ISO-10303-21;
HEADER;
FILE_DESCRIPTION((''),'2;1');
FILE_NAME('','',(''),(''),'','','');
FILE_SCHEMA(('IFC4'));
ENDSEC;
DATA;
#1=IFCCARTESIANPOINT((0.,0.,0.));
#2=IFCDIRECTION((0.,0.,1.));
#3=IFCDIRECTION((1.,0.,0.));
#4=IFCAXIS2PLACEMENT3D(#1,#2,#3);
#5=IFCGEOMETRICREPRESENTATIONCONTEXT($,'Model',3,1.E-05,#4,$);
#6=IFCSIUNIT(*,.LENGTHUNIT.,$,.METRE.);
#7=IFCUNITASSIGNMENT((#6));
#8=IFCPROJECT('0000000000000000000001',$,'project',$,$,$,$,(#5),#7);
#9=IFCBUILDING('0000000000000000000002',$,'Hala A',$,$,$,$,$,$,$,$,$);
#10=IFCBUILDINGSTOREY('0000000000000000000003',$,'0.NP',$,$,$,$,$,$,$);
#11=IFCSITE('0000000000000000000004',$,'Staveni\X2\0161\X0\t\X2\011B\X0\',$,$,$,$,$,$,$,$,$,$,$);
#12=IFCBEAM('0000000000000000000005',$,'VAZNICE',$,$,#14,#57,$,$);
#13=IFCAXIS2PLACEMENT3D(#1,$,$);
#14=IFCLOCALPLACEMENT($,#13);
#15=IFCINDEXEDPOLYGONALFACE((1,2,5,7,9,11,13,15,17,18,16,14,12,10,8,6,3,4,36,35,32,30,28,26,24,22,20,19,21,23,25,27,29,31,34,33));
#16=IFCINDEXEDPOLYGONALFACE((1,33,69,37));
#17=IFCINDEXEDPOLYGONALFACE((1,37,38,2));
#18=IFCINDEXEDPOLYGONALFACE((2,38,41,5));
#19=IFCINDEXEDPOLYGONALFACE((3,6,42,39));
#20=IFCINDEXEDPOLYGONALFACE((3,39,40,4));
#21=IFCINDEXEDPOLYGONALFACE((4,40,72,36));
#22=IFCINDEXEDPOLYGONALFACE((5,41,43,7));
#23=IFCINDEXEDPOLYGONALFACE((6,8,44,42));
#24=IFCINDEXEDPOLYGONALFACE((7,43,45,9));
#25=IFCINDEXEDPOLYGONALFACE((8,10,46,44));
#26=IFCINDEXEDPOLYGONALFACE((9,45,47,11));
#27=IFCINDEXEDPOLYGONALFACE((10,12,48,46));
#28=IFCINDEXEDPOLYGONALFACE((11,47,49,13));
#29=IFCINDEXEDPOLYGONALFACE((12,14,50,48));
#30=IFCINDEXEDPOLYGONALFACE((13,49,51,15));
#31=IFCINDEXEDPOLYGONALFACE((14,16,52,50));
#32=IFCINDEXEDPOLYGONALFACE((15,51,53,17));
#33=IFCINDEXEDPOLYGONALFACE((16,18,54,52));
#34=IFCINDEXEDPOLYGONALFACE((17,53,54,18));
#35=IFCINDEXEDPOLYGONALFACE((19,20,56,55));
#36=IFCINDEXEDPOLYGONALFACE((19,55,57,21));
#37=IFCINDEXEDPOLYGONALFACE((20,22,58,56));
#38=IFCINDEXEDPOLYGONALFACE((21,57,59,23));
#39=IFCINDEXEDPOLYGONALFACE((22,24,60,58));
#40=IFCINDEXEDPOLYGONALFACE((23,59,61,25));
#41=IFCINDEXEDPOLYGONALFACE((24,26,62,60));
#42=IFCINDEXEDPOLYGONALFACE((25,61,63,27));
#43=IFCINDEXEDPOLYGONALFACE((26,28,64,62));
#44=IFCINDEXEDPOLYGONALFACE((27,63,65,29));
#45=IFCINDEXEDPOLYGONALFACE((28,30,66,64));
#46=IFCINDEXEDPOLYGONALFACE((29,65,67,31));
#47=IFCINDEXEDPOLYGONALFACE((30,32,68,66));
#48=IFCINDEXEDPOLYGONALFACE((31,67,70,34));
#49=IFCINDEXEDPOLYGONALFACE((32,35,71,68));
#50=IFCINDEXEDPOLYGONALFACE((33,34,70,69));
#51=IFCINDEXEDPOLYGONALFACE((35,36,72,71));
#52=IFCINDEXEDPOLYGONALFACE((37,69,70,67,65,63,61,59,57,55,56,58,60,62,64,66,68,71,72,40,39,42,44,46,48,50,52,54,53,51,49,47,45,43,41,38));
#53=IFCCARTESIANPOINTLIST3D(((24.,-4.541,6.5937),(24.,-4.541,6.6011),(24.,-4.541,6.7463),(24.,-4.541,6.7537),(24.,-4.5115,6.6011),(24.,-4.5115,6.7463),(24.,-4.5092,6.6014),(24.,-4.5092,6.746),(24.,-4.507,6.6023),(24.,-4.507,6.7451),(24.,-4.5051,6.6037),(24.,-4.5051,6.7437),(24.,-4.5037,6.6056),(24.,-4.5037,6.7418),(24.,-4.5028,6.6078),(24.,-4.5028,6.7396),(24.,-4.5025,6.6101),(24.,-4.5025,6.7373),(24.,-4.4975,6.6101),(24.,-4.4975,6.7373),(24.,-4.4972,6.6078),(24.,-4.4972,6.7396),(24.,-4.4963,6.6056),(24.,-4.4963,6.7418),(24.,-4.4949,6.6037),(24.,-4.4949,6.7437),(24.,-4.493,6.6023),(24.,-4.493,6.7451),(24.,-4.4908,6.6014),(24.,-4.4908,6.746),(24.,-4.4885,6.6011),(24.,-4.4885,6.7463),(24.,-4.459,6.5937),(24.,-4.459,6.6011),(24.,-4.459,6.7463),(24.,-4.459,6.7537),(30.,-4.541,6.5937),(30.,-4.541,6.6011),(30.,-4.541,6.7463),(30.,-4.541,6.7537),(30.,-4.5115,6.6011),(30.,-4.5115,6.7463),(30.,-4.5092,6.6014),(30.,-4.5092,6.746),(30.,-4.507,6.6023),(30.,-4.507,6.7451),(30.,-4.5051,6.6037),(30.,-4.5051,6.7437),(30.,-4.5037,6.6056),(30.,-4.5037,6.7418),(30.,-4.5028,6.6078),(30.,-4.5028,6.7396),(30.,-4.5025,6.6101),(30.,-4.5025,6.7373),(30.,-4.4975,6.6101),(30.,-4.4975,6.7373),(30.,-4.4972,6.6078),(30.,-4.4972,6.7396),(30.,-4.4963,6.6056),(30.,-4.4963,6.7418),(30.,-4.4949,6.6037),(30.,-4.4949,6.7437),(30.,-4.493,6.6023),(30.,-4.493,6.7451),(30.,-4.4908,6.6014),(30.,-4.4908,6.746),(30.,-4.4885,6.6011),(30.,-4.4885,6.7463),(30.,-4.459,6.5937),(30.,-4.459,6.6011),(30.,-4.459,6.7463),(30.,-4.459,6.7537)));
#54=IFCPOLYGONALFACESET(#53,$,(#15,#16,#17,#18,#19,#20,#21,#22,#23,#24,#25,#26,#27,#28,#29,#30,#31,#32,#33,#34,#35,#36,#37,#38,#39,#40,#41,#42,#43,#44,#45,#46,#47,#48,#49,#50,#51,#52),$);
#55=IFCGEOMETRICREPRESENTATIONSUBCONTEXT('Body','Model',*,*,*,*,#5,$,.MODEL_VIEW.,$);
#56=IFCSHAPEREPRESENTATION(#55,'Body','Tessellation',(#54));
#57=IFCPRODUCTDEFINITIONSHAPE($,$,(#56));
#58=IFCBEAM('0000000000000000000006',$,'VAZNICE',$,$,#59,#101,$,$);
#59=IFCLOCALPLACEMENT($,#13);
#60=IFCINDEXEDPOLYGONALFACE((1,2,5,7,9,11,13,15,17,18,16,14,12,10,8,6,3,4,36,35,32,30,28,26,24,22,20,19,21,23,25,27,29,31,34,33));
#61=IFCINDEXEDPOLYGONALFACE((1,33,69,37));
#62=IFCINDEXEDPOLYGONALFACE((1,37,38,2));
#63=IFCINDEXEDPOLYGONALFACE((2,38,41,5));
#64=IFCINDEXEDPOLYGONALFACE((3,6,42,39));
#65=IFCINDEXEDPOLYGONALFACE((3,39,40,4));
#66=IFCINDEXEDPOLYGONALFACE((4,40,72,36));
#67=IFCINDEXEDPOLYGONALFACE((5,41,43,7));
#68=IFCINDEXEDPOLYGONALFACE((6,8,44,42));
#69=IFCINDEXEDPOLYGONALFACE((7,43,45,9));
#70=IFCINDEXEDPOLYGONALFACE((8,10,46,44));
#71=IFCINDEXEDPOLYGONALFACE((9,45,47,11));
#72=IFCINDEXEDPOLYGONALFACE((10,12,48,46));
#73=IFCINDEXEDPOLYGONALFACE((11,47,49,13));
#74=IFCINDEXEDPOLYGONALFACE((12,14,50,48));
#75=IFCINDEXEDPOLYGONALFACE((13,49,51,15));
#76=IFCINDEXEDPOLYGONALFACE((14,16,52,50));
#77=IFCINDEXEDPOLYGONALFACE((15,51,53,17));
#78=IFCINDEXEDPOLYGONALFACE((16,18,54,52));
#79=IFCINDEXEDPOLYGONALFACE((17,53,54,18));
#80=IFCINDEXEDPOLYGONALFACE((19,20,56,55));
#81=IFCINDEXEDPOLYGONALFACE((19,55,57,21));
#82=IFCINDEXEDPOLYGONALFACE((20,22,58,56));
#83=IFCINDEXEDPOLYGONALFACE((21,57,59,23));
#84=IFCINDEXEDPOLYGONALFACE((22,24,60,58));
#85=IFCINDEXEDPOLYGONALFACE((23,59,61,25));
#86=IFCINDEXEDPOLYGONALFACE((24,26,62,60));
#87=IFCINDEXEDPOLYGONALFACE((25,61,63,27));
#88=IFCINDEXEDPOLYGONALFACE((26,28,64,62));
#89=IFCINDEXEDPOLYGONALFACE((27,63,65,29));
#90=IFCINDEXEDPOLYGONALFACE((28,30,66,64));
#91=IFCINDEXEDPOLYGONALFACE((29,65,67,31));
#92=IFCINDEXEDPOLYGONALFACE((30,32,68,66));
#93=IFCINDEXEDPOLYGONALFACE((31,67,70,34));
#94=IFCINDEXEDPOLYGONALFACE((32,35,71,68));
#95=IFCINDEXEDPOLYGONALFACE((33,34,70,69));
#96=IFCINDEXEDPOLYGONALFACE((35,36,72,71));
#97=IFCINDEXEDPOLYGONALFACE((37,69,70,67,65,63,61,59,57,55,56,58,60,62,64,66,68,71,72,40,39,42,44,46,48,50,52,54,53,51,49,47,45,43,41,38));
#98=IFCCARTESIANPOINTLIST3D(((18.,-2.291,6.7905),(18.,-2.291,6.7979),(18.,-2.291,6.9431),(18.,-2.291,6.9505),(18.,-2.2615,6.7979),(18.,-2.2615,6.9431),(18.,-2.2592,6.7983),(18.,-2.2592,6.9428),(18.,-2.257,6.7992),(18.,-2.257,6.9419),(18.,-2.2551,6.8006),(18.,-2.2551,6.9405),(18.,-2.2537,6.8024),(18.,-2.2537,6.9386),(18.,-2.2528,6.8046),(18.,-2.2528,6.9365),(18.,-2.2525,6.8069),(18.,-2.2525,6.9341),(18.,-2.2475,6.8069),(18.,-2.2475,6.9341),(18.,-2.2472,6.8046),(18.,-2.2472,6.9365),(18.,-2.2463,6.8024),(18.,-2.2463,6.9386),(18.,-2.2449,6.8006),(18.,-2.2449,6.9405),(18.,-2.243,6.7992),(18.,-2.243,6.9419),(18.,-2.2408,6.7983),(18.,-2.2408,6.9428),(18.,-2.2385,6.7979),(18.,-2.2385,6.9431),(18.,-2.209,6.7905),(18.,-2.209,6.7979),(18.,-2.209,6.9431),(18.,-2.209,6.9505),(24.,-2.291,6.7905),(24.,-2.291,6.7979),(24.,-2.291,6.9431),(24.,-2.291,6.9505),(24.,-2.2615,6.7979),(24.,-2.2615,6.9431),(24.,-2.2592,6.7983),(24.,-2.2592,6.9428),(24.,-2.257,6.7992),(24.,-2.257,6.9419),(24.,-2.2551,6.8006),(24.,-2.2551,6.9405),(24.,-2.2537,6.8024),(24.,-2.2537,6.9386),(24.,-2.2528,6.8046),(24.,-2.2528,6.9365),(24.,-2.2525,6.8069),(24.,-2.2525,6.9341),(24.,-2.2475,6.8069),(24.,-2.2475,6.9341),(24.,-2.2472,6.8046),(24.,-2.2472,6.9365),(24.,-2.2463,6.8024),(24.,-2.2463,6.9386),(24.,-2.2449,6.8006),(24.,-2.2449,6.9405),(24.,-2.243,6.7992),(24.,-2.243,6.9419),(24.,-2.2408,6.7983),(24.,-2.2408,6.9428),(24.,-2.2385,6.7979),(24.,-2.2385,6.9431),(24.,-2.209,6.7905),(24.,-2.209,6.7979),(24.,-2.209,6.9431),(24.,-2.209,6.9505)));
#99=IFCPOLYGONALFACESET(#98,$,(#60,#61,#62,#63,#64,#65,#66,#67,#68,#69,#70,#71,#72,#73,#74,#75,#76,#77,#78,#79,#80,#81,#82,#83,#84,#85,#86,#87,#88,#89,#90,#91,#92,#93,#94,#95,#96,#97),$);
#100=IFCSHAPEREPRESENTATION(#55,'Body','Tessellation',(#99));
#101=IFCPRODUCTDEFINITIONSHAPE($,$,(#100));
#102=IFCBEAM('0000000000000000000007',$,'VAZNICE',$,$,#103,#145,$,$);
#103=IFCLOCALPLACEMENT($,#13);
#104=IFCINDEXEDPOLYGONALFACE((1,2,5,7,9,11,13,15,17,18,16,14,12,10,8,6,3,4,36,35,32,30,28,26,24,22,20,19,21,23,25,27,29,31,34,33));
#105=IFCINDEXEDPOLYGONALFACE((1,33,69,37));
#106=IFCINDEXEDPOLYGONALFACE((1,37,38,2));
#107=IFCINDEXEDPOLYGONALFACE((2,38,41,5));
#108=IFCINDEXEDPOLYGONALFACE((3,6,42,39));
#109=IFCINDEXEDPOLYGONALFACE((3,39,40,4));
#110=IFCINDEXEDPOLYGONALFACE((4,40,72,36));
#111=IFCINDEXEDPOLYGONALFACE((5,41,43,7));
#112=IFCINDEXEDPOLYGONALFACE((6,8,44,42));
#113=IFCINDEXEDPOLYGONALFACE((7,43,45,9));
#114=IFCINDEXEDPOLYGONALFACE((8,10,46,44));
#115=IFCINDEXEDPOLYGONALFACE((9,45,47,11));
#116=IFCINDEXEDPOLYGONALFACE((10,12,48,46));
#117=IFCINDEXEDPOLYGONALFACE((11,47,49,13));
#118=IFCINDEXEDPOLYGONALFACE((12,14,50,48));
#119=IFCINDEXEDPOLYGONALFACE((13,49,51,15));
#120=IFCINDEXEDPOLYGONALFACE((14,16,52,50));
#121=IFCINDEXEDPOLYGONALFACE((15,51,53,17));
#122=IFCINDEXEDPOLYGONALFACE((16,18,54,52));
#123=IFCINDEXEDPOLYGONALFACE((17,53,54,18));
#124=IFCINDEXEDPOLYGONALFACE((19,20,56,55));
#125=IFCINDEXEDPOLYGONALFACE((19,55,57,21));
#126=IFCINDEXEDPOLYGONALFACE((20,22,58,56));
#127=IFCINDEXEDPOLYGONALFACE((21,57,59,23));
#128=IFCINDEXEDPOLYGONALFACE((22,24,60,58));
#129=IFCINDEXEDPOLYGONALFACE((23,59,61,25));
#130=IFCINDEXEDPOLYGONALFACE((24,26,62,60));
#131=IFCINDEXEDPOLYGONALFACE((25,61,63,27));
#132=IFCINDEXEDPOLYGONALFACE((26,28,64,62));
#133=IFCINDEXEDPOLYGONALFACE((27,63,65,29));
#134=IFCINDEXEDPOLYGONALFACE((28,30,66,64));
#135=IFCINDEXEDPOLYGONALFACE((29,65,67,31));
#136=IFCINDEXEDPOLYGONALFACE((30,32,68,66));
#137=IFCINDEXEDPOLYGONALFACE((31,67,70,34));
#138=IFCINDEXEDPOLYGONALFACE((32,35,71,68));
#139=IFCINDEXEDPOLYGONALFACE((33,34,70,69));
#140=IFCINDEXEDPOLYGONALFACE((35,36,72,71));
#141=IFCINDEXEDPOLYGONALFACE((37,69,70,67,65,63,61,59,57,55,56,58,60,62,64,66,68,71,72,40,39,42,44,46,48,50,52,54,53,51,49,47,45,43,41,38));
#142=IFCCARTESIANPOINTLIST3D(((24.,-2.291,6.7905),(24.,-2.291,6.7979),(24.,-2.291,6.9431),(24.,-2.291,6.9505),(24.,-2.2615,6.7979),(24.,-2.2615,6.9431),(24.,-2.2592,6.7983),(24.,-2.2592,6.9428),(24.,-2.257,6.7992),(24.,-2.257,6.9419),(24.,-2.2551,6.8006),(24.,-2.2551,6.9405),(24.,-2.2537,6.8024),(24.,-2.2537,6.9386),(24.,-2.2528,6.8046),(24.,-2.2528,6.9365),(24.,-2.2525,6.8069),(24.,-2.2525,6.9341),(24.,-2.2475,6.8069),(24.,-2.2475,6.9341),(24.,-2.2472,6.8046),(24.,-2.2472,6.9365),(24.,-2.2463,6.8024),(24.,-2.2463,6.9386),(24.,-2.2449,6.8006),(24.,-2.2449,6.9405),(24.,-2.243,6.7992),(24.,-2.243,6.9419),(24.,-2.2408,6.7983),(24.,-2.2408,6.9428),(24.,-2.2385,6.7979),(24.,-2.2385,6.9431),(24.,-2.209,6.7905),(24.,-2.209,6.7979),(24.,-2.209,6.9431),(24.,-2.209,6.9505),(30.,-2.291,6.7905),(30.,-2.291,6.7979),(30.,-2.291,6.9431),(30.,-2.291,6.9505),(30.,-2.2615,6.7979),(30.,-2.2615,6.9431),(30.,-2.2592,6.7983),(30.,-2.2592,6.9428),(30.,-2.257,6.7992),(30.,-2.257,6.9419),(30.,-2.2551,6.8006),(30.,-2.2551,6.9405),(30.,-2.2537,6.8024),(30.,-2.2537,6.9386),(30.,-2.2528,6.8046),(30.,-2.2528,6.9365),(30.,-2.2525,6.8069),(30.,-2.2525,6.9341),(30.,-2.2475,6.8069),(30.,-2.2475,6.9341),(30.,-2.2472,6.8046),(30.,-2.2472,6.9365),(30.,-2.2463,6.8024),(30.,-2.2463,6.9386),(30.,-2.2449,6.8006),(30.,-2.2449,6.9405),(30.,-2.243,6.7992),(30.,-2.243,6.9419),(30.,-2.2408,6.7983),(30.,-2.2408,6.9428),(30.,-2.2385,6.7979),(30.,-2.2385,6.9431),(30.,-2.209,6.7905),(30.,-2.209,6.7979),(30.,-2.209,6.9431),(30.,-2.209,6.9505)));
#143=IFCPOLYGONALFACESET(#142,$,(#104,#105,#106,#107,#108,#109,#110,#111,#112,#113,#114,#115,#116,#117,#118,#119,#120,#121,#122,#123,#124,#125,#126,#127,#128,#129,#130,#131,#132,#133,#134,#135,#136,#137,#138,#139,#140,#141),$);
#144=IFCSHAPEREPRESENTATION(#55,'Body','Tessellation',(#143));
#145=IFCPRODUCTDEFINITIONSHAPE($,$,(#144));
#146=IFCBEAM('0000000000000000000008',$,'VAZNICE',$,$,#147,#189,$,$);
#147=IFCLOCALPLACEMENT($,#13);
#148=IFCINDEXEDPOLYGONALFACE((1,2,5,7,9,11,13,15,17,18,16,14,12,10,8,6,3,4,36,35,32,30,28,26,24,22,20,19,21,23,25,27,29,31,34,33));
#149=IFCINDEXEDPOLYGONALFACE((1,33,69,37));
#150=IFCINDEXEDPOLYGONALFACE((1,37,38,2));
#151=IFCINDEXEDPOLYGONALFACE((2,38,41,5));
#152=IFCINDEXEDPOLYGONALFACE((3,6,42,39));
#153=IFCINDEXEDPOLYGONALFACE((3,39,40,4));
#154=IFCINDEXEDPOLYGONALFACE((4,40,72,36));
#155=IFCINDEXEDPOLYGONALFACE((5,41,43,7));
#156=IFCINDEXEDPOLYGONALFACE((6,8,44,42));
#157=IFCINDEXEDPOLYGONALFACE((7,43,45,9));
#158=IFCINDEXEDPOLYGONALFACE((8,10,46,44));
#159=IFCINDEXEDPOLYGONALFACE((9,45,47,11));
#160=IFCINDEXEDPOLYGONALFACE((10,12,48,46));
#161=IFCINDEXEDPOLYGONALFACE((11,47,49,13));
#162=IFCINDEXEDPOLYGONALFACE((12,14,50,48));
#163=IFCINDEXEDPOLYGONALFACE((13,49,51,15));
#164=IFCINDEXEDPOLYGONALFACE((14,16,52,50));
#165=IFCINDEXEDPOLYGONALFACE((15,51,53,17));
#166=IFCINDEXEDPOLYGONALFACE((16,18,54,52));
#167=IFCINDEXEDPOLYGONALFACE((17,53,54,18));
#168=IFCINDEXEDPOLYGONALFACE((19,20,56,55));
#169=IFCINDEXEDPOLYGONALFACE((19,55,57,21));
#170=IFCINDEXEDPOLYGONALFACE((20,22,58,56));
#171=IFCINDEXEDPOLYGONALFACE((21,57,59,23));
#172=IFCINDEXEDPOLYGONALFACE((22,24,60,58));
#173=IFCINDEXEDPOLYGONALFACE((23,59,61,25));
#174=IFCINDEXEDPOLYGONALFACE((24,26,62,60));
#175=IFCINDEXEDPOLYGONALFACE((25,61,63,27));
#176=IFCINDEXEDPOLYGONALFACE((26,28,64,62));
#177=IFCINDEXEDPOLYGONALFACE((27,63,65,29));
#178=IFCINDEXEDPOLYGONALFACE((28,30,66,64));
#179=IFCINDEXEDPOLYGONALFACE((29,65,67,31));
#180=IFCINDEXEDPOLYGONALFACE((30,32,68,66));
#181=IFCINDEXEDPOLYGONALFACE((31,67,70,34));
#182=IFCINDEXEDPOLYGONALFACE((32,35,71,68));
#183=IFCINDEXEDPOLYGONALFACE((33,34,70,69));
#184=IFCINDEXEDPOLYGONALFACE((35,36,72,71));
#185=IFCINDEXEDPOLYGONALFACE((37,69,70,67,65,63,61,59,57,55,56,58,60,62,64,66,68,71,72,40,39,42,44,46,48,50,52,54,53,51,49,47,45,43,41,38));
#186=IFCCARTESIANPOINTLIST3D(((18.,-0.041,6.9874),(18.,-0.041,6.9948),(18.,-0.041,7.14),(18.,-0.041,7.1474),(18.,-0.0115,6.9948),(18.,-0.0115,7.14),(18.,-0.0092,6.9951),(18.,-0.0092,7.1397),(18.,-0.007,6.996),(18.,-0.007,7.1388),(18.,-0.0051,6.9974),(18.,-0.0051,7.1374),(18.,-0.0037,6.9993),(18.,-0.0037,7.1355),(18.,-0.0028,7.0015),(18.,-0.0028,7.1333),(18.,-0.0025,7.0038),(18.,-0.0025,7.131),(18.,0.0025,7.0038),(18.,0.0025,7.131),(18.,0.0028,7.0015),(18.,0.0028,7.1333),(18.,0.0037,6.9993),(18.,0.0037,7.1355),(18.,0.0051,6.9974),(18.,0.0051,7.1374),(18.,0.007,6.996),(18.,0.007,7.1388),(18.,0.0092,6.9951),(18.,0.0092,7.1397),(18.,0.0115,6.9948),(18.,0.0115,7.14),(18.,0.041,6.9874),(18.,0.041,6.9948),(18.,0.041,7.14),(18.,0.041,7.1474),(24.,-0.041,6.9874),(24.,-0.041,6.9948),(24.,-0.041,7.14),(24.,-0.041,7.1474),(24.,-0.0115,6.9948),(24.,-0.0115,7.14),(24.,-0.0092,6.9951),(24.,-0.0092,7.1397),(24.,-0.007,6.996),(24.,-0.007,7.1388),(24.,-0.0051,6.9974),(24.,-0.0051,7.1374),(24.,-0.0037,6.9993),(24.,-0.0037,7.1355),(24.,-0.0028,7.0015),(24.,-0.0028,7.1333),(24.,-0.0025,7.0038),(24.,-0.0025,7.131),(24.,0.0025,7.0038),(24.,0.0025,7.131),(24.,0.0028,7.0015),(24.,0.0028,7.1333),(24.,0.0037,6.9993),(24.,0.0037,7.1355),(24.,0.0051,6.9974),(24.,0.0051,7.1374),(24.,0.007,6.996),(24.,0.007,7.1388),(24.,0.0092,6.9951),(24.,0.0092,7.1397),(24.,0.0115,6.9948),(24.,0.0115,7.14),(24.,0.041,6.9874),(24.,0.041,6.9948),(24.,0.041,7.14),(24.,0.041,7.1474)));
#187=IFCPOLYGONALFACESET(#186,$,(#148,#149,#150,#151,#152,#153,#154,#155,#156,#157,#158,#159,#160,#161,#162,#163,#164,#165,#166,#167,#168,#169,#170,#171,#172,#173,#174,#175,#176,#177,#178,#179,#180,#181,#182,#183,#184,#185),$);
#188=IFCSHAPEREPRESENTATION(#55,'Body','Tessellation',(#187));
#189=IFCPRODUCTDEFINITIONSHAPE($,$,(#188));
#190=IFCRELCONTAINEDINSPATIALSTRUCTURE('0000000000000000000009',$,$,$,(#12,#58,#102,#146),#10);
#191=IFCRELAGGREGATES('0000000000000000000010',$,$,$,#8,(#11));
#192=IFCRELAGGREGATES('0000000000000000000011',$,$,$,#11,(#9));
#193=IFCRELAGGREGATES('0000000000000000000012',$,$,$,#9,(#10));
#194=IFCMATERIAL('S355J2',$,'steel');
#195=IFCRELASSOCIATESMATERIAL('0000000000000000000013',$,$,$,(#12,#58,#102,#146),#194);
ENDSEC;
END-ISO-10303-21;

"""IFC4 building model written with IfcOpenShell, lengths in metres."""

from ifc_helpers import new_model, si_unit, frame, origin_with_axes, place, context, subcontext, project, spatial, i_section, extrude, material, element, save


model = new_model("IFC4")

# Units and contexts
model_context = context("Model", 3, precision=1e-05, world=origin_with_axes())
body_context = subcontext(model_context, "Body", "Model", "MODEL_VIEW")
ifc_project = project(units=[si_unit("LENGTHUNIT", "METRE")], contexts=[model_context])

# Site, building, storey
site = spatial("IfcSite", under=ifc_project, Name="Staveniště")
building = spatial("IfcBuilding", under=site, Name="Hala A")
storey = spatial("IfcBuildingStorey", under=building, Name="0.NP")

# Shared definitions
ifc_material = material(Name="S355J2", Category="steel")

# Beams
for number, where, z_axis, x_axis, name in (
    (1, (24.0, -4.5, 6.6737), (1.0, 0.0, 0.0), (0.0, 1.0, 0.0), "VAZNICE"),
    (2, (18.0, -2.25, 6.8705), (1.0, 0.0, 0.0), (0.0, 1.0, 0.0), "VAZNICE"),
    (3, (24.0, -2.25, 6.8705), (1.0, 0.0, 0.0), (0.0, 1.0, 0.0), "VAZNICE"),
    (4, (18.0, 0.0, 7.0674), (1.0, 0.0, 0.0), (0.0, 1.0, 0.0), "VAZNICE"),
):
    element("IfcBeam", number, at=place(None, frame(where, z_axis=z_axis, x_axis=x_axis)), inside=storey, material=ifc_material, Name=name, context=body_context, shape_type="SweptSolid", body=[
        extrude(i_section(OverallWidth=0.082, OverallDepth=0.16, WebThickness=0.005, FlangeThickness=0.0074, FilletRadius=0.009), origin_with_axes(), (0.0, 0.0, 1.0), 6.0),
    ])

save(model, "model.ifc")
